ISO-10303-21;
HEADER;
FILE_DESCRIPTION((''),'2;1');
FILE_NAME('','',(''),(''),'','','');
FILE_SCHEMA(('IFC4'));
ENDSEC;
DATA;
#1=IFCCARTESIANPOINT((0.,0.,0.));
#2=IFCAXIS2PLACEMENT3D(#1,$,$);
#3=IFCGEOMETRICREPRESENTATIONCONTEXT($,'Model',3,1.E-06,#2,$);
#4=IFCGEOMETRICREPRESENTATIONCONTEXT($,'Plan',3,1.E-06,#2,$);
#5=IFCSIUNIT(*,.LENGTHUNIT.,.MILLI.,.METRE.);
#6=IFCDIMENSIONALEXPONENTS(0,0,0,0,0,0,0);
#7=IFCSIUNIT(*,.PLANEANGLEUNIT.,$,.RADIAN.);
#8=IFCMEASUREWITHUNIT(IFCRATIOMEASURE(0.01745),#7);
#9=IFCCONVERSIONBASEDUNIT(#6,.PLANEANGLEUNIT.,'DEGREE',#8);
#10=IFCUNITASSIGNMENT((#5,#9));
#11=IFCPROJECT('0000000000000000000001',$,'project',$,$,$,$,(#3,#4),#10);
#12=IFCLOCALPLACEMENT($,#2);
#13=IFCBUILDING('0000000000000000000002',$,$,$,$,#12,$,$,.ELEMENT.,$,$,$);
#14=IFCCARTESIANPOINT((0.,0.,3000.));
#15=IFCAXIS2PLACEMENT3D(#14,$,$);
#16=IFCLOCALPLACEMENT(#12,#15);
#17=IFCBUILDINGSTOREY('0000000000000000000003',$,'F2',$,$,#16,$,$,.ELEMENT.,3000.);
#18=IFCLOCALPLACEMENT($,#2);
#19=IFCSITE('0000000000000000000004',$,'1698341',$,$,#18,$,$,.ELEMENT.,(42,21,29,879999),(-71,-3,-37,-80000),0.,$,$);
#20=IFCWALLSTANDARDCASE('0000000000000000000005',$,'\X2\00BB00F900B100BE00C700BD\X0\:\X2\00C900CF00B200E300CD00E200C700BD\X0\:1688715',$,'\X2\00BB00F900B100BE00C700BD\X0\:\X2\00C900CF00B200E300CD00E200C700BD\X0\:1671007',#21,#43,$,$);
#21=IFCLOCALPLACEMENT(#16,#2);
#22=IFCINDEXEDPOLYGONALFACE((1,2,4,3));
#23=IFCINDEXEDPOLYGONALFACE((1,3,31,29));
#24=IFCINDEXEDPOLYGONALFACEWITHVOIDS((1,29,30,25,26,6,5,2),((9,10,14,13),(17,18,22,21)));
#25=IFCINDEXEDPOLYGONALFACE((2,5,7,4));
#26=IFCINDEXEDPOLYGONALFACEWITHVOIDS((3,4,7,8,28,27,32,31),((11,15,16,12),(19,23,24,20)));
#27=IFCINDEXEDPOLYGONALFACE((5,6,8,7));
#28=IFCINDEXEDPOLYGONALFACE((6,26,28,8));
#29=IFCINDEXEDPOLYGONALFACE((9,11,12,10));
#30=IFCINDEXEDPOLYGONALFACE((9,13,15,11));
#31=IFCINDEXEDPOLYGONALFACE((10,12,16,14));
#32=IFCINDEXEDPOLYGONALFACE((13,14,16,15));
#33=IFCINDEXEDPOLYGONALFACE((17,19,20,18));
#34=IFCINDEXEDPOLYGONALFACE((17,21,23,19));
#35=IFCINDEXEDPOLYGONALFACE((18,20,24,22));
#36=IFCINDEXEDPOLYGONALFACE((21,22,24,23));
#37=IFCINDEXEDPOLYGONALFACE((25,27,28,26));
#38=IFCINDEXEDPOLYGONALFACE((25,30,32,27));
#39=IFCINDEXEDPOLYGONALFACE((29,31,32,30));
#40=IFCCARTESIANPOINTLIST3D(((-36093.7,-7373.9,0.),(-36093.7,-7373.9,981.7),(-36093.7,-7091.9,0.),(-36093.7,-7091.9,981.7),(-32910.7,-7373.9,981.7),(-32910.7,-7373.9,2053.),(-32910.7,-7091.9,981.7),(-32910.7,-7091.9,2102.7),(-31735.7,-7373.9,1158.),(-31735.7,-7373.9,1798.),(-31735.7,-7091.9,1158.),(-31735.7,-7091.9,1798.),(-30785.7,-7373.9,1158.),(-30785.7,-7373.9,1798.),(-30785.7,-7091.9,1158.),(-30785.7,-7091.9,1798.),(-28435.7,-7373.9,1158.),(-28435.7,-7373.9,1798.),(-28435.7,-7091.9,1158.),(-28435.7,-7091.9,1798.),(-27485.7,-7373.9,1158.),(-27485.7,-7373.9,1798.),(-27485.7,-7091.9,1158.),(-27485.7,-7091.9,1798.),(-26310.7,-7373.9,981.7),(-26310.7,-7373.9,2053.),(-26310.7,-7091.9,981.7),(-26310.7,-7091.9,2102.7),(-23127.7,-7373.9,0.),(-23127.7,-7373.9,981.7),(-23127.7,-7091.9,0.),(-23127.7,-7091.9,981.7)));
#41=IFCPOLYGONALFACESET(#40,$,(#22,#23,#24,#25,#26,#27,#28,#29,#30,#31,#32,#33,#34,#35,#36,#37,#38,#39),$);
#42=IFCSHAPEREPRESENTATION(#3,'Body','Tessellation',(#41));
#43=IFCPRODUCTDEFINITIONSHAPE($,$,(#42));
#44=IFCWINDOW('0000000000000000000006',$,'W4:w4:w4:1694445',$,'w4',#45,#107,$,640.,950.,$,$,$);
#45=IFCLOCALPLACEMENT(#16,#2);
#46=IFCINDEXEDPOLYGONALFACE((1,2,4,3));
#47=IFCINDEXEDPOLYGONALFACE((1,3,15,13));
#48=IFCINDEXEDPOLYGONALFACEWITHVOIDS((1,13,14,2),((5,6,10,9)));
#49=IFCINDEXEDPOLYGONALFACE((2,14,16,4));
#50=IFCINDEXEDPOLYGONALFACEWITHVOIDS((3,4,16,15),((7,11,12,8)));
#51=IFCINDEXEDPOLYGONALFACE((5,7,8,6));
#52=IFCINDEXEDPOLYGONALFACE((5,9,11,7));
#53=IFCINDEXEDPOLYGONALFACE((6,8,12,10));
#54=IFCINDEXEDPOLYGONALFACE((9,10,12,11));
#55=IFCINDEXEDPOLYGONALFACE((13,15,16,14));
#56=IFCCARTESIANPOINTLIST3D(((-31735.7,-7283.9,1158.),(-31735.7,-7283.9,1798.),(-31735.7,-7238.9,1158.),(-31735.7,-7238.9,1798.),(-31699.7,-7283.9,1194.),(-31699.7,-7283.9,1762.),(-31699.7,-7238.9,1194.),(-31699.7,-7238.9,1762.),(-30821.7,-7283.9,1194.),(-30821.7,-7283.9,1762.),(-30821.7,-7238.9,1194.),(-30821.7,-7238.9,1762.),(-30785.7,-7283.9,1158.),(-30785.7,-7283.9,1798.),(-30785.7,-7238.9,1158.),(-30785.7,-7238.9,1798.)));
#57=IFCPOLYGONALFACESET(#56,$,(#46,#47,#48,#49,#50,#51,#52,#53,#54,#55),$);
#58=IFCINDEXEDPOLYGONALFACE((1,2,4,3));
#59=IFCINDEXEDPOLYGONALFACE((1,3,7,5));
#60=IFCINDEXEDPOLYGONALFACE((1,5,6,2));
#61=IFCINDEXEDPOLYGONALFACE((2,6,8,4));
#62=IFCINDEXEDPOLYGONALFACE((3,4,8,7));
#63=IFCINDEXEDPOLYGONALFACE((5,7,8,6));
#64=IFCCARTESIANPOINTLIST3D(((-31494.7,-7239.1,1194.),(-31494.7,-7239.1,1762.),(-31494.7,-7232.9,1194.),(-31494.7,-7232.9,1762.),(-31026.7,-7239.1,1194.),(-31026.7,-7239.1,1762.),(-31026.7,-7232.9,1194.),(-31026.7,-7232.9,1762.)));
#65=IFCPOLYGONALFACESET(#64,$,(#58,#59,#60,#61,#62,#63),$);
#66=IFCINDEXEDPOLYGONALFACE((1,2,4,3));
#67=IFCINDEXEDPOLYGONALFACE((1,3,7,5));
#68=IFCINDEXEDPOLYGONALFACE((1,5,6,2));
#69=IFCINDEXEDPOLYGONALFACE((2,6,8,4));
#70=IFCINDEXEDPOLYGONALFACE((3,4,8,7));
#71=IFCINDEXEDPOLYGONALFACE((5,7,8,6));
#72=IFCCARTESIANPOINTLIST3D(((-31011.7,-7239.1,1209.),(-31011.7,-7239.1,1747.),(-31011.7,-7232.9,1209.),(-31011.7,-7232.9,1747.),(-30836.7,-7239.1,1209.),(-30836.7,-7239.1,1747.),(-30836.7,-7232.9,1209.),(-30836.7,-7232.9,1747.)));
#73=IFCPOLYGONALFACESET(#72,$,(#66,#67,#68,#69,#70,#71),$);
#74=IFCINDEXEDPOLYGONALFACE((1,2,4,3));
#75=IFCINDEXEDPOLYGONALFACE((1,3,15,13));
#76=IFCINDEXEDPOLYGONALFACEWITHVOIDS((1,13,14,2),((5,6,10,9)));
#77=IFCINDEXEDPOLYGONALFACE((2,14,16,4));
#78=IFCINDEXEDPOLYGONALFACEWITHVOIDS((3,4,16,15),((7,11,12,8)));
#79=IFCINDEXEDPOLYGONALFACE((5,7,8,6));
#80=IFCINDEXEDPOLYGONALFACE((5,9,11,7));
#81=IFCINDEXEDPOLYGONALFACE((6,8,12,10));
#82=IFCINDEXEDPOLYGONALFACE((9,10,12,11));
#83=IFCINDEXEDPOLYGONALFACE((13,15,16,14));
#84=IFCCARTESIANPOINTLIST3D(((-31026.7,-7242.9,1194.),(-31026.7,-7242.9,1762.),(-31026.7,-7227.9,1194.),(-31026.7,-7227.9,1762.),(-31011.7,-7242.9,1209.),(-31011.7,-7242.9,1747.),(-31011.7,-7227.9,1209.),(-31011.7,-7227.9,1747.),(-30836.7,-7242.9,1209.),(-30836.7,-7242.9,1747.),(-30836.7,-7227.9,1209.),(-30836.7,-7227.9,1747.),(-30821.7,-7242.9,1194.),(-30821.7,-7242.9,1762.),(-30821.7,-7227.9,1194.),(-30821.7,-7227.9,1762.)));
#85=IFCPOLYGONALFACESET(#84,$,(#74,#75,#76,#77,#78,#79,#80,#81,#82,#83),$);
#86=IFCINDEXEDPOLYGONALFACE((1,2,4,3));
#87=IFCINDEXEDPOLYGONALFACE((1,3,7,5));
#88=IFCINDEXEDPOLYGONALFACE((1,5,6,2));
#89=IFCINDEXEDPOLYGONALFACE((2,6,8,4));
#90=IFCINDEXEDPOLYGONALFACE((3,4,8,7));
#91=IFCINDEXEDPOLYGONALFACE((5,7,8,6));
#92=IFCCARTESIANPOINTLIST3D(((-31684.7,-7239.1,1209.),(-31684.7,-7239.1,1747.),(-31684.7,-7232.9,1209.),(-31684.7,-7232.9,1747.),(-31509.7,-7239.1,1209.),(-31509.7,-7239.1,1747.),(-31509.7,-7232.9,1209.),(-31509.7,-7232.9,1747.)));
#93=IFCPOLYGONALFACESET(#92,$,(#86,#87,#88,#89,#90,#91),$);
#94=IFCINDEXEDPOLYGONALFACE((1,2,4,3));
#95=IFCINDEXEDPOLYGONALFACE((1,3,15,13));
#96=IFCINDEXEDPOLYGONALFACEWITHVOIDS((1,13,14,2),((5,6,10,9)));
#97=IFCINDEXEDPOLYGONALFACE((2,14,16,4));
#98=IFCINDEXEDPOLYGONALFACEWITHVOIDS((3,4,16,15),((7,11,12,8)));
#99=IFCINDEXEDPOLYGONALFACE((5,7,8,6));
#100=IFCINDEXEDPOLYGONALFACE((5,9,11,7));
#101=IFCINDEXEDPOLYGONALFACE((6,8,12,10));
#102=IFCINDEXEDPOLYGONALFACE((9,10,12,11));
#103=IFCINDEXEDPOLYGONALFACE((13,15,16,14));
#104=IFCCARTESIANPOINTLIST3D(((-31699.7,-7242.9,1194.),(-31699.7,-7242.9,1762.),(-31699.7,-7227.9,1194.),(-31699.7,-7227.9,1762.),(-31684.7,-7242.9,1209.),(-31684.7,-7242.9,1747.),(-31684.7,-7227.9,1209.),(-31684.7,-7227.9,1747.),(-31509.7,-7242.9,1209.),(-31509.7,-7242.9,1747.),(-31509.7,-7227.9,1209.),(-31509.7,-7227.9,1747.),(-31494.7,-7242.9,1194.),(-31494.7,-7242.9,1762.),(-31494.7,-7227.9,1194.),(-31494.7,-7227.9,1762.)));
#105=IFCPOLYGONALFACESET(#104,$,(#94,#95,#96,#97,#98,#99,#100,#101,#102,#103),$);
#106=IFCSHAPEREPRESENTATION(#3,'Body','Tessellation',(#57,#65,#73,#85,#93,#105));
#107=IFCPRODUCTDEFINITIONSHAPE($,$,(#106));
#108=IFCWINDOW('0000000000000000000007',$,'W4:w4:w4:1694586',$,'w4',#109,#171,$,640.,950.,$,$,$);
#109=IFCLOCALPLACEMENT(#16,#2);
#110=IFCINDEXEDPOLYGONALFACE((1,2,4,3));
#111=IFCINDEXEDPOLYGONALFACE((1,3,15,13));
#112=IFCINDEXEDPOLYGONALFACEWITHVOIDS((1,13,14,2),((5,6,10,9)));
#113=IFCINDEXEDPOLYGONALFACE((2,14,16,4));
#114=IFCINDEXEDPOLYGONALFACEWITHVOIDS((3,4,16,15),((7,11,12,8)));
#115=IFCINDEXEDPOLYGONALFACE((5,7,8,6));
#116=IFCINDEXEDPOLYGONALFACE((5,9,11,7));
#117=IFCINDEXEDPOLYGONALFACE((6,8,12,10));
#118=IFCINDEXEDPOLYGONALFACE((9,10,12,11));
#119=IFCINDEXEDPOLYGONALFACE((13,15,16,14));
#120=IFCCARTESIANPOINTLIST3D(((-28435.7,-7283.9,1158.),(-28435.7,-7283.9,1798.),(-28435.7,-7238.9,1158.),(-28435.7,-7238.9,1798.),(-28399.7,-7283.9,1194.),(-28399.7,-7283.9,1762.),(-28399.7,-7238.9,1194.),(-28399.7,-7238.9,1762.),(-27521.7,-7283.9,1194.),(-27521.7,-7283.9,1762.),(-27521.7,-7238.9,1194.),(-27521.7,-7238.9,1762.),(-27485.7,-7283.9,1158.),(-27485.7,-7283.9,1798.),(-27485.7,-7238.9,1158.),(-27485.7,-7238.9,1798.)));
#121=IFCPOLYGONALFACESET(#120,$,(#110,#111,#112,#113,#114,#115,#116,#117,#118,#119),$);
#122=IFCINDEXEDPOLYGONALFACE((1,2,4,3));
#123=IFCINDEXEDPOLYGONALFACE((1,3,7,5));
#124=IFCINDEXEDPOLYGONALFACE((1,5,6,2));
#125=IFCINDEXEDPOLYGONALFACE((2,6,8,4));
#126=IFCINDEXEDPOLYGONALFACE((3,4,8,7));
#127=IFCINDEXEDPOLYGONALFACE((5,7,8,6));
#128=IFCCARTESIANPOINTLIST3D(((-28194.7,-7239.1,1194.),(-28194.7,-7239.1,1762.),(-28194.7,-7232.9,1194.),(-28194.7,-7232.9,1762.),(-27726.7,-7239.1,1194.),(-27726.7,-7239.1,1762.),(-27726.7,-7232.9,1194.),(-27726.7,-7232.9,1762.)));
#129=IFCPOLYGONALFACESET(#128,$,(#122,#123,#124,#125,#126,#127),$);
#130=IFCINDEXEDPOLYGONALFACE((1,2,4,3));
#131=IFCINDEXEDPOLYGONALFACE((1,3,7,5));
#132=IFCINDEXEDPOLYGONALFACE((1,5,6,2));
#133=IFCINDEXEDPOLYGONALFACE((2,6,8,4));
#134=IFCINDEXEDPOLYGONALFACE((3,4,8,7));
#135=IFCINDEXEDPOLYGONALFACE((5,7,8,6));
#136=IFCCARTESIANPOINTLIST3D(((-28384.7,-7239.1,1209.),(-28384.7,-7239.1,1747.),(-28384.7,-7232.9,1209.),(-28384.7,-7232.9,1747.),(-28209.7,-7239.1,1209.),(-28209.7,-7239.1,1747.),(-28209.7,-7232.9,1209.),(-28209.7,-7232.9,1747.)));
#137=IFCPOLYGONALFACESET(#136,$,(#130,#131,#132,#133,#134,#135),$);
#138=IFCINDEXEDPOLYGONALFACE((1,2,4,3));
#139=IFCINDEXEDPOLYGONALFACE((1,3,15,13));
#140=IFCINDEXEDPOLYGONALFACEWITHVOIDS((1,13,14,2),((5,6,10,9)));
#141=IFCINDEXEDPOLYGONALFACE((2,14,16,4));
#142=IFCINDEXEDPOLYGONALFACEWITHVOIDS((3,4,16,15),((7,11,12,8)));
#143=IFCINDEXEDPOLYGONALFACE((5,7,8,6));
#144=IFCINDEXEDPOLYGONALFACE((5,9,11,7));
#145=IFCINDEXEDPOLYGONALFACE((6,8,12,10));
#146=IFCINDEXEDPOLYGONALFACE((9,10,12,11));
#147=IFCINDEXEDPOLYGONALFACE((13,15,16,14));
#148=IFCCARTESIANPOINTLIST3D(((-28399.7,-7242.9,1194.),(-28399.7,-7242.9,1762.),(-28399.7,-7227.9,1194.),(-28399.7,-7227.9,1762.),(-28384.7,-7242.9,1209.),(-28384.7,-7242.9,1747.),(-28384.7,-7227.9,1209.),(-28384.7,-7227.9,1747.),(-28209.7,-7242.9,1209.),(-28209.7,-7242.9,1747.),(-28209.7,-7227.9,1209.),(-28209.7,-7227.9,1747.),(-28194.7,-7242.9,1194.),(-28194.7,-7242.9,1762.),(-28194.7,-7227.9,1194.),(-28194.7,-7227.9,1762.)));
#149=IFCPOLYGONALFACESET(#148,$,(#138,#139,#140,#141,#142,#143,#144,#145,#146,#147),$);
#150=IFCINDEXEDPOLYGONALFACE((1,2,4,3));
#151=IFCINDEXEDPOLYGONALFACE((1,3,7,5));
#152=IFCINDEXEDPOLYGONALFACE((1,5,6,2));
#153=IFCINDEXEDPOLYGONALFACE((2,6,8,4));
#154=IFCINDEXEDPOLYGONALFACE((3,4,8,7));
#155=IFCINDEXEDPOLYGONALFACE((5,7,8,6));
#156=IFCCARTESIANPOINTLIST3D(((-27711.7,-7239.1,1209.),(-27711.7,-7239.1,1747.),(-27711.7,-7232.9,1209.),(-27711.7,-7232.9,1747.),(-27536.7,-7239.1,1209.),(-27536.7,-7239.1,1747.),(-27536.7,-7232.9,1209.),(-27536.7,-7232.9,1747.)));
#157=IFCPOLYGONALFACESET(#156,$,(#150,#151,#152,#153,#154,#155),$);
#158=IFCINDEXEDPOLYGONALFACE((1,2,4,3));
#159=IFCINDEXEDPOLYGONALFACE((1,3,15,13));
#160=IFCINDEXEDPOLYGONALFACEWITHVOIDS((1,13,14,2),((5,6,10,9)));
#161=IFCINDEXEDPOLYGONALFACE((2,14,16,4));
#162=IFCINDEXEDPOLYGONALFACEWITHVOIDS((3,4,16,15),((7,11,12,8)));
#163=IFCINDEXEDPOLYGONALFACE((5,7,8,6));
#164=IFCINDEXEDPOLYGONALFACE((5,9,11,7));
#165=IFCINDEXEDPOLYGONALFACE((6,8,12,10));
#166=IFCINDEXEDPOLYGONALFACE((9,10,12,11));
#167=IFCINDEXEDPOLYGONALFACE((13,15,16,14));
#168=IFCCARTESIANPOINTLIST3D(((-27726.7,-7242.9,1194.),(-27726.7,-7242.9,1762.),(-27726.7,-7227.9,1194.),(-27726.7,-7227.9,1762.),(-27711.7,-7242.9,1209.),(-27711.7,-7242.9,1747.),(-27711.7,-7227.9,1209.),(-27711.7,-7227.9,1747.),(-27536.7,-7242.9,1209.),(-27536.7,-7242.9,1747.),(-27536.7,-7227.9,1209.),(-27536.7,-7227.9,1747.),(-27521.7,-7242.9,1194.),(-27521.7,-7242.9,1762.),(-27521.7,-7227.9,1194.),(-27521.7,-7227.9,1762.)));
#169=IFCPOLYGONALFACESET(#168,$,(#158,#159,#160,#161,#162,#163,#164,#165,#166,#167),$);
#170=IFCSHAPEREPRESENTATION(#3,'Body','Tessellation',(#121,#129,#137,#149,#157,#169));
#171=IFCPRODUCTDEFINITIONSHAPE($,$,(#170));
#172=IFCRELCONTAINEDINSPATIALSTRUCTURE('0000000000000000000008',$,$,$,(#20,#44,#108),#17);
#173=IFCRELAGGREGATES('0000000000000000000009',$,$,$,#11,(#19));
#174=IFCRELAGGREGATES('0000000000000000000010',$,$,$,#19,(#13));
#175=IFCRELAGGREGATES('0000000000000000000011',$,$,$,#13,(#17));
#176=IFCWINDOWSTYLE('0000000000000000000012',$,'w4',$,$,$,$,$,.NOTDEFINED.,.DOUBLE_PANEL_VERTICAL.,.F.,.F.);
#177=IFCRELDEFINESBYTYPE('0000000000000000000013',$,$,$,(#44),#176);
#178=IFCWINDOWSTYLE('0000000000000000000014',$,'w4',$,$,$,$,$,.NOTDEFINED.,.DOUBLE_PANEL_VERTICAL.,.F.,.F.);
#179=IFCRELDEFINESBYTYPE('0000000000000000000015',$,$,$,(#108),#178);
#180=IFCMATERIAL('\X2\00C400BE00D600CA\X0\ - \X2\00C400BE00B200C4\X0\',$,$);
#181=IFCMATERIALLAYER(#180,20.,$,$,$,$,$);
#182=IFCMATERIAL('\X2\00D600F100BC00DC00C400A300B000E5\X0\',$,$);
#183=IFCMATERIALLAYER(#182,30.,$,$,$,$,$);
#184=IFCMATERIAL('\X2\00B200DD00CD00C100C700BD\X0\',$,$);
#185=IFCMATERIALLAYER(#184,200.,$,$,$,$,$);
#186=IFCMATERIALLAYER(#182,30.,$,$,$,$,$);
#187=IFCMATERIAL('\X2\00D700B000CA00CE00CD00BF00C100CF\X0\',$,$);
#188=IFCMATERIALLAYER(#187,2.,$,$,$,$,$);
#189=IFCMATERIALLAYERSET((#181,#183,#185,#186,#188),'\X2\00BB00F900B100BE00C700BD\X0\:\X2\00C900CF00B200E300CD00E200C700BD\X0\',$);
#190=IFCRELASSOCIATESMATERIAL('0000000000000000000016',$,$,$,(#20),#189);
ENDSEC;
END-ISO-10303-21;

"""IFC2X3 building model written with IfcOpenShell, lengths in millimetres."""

from ifc_helpers import new_model, entity, si_unit, converted_unit, frame, frame_2d, origin, origin_2d_with_axis, place, context, project, spatial, polyline, rectangle, outline, extrude, clip, halfspace, bounded_halfspace, source, transform, mapped, material, layer, layer_set, layer_usage, type_object, type_shapes, element, fill, save


model = new_model("IFC2X3")

# Units and contexts
model_context = context("Model", 3, precision=1e-06, world=origin())
plan_context = context("Plan", 3, precision=1e-06, world=origin())
ifc_project = project(units=[si_unit("LENGTHUNIT", "METRE", prefix="MILLI"), converted_unit("PLANEANGLEUNIT", "DEGREE", entity("IfcRatioMeasure", 0.01745), si_unit("PLANEANGLEUNIT", "RADIAN"), dimensions=[0, 0, 0, 0, 0, 0, 0])], contexts=[model_context, plan_context])

# Site, building, storey
site_placement = place(None, origin())
site = spatial("IfcSite", under=ifc_project, at=site_placement, Name="1698341", CompositionType="ELEMENT", RefLatitude=(42, 21, 29, 879999), RefLongitude=(-71, -3, -37, -80000), RefElevation=0.0)
building_placement = place(None, origin())
building = spatial("IfcBuilding", under=site, at=building_placement, CompositionType="ELEMENT")
storey_placement = place(building_placement, frame((0.0, 0.0, 3000.0)))
storey = spatial("IfcBuildingStorey", under=building, at=storey_placement, Name="F2", CompositionType="ELEMENT", Elevation=3000.0)

# Shared definitions
ifc_material_1 = material(Name="Öñ¼ÜÄ£°å")

# Shared definitions
ifc_material_2 = material(Name="Ä¾ÖÊ - Ä¾²Ä")
ifc_layer_1 = layer(ifc_material_2, 20.0)
ifc_layer_2 = layer(ifc_material_1, 30.0)
ifc_material_3 = material(Name="²ÝÍÁÇ½")
ifc_layer_3 = layer(ifc_material_3, 200.0)
ifc_layer_4 = layer(ifc_material_1, 30.0)
ifc_material_4 = material(Name="×°ÊÎÍ¿ÁÏ")
ifc_layer_5 = layer(ifc_material_4, 2.0)
ifc_layer_set_1 = layer_set([ifc_layer_1, ifc_layer_2, ifc_layer_3, ifc_layer_4, ifc_layer_5], Name="»ù±¾Ç½:ÉÏ²ãÍâÇ½")

# Shared definitions
window_style_1 = type_object("IfcWindowStyle", Name="w4", ConstructionType="NOTDEFINED", OperationType="DOUBLE_PANEL_VERTICAL", ParameterTakesPrecedence=False, Sizeable=False)
shared_shape_1 = source(origin(), model_context, "Body", "SweptSolid", [
    extrude(outline(polyline([(-320.0, -475.0), (320.0, -475.0), (320.0, 475.0), (-320.0, 475.0), (-320.0, -475.0)]), holes=[polyline([(284.0, -439.0), (-284.0, -439.0), (-284.0, 439.0), (284.0, 439.0), (284.0, -439.0)])]), frame((475.0, -135.0, 320.0), z_axis=(0.0, 1.0, 0.0), x_axis=(0.0, 0.0, 1.0)), (0.0, 0.0, 1.0), 45.0),
    extrude(rectangle(XDim=6.3, YDim=468.0, at=origin_2d_with_axis()), frame((475.0, -137.9, 36.0), z_axis=(0.0, 0.0, 1.0), x_axis=(0.0, 1.0, 0.0)), (0.0, 0.0, 1.0), 568.0),
    extrude(rectangle(XDim=6.3, YDim=175.0, at=origin_2d_with_axis()), frame((138.5, -137.9, 51.0), z_axis=(0.0, 0.0, 1.0), x_axis=(0.0, 1.0, 0.0)), (0.0, 0.0, 1.0), 538.0),
    extrude(outline(polyline([(-102.5, -284.0), (102.5, -284.0), (102.5, 284.0), (-102.5, 284.0), (-102.5, -284.0)]), holes=[polyline([(87.5, -269.0), (-87.5, -269.0), (-87.5, 269.0), (87.5, 269.0), (87.5, -269.0)])]), frame((138.5, -146.0, 320.0), z_axis=(0.0, 1.0, 0.0), x_axis=(-1.0, 0.0, 0.0)), (0.0, 0.0, 1.0), 15.0),
    extrude(rectangle(XDim=6.3, YDim=175.0, at=origin_2d_with_axis()), frame((811.5, -137.9, 51.0), z_axis=(0.0, 0.0, 1.0), x_axis=(0.0, 1.0, 0.0)), (0.0, 0.0, 1.0), 538.0),
    extrude(outline(polyline([(-102.5, -284.0), (102.5, -284.0), (102.5, 284.0), (-102.5, 284.0), (-102.5, -284.0)]), holes=[polyline([(87.5, -269.0), (-87.5, -269.0), (-87.5, 269.0), (87.5, 269.0), (87.5, -269.0)])]), frame((811.5, -146.0, 320.0), z_axis=(0.0, 1.0, 0.0), x_axis=(-1.0, 0.0, 0.0)), (0.0, 0.0, 1.0), 15.0),
])
type_shapes(window_style_1, [shared_shape_1])
window_style_2 = type_object("IfcWindowStyle", Name="w4", ConstructionType="NOTDEFINED", OperationType="DOUBLE_PANEL_VERTICAL", ParameterTakesPrecedence=False, Sizeable=False)
shared_shape_2 = source(origin(), model_context, "Body", "SweptSolid", [
    extrude(outline(polyline([(-475.0, -320.0), (475.0, -320.0), (475.0, 320.0), (-475.0, 320.0), (-475.0, -320.0)]), holes=[polyline([(-439.0, 284.0), (439.0, 284.0), (439.0, -284.0), (-439.0, -284.0), (-439.0, 284.0)])]), frame((-177.3, 192.0, 320.0), z_axis=(0.0, -1.0, 0.0), x_axis=(-1.0, 0.0, 0.0)), (0.0, 0.0, 1.0), 45.0),
    extrude(rectangle(XDim=468.0, YDim=6.3, at=origin_2d_with_axis()), frame((-177.3, 144.1, 36.0)), (0.0, 0.0, 1.0), 568.0),
    extrude(rectangle(XDim=175.0, YDim=6.3, at=origin_2d_with_axis()), frame((159.2, 144.1, 51.0)), (0.0, 0.0, 1.0), 538.0),
    extrude(outline(polyline([(-284.0, -102.5), (284.0, -102.5), (284.0, 102.5), (-284.0, 102.5), (-284.0, -102.5)]), holes=[polyline([(-269.0, 87.5), (269.0, 87.5), (269.0, -87.5), (-269.0, -87.5), (-269.0, 87.5)])]), frame((159.2, 151.0, 320.0), z_axis=(0.0, -1.0, 0.0), x_axis=(0.0, 0.0, 1.0)), (0.0, 0.0, 1.0), 15.0),
    extrude(rectangle(XDim=175.0, YDim=6.3, at=origin_2d_with_axis()), frame((-513.8, 144.1, 51.0)), (0.0, 0.0, 1.0), 538.0),
    extrude(outline(polyline([(-284.0, -102.5), (284.0, -102.5), (284.0, 102.5), (-284.0, 102.5), (-284.0, -102.5)]), holes=[polyline([(-269.0, 87.5), (269.0, 87.5), (269.0, -87.5), (-269.0, -87.5), (-269.0, 87.5)])]), frame((-513.8, 151.0, 320.0), z_axis=(0.0, -1.0, 0.0), x_axis=(0.0, 0.0, 1.0)), (0.0, 0.0, 1.0), 15.0),
])
type_shapes(window_style_2, [shared_shape_2])

# Wall, openings, windows
ifc_layer_usage_1 = layer_usage(ifc_layer_set_1, "AXIS2", "NEGATIVE", 141.0)
wall_1_placement = place(storey_placement, frame((-23127.7, -7232.9, 0.0), z_axis=(0.0, 0.0, 1.0), x_axis=(-1.0, 0.0, 0.0)))
wall_1 = element("IfcWallStandardCase", 1, at=wall_1_placement, inside=storey, material=ifc_layer_usage_1, Name="»ù±¾Ç½:ÉÏ²ãÍâÇ½:1688715", ObjectType="»ù±¾Ç½:ÉÏ²ãÍâÇ½:1671007", context=model_context, shape_type="Clipping", body=[
    clip(clip(clip(extrude(rectangle(XDim=12966.0, YDim=282.0, at=frame_2d((6483.0, 0.0), x_axis=(-1.0, 0.0))), origin(), (0.0, 0.0, 1.0), 3200.0), bounded_halfspace(frame((3098.0, -141.0, 2102.7), z_axis=(0.0, -0.1736, -0.9848), x_axis=(1.0, 0.0, 0.0)), True, frame((3098.0, -141.0, 2102.7)), polyline([(0.0, 0.0), (170.0, 0.0), (3280.0, 0.0), (3490.0, 0.0), (6600.0, 0.0), (6770.0, 0.0), (6770.0, 282.0), (0.0, 282.0), (0.0, 0.0)]))), halfspace(frame((13107.0, 0.0, 981.7), z_axis=(0.5551, 0.0, 0.8318), x_axis=(0.0, 1.0, 0.0)), False)), halfspace(frame((3183.0, 0.0, 3200.0), z_axis=(-0.5551, 0.0, 0.8318), x_axis=(0.0, 1.0, 0.0)), False)),
])
opening_1_placement = place(wall_1_placement, origin())
opening_1 = element("IfcOpeningElement", 2, at=opening_1_placement, cuts=wall_1, ObjectType="Opening", context=model_context, shape_type="SweptSolid", body=[
    extrude(rectangle(XDim=640.0, YDim=950.0, at=frame_2d((0.0, 0.0), x_axis=(0.0, 1.0))), frame((8133.0, -141.0, 1478.0), z_axis=(0.0, 1.0, 0.0), x_axis=(-1.0, 0.0, 0.0)), (0.0, 0.0, 1.0), 282.0),
])
opening_2_placement = place(wall_1_placement, origin())
opening_2 = element("IfcOpeningElement", 3, at=opening_2_placement, cuts=wall_1, ObjectType="Opening", context=model_context, shape_type="SweptSolid", body=[
    extrude(rectangle(XDim=640.0, YDim=950.0, at=origin_2d_with_axis()), frame((4833.0, -141.0, 1478.0), z_axis=(0.0, 1.0, 0.0), x_axis=(0.0, 0.0, 1.0)), (0.0, 0.0, 1.0), 282.0),
])
opening_3_placement = place(wall_1_placement, frame((10891.0, 141.0, 1721.1)))
element("IfcOpeningElement", 4, at=opening_3_placement, cuts=wall_1, ObjectType="Opening", context=model_context, shape_type="SweptSolid", body=[
    extrude(outline(polyline([(-2253.7, -615.1), (1742.5, -615.1), (511.2, 1230.1), (-2253.7, -615.1)])), frame((0.0, 0.0, 0.0), z_axis=(0.0, -1.0, 0.0), x_axis=(-0.8318, 0.0, 0.5551)), (0.0, 0.0, 1.0), 282.0),
])
opening_4_placement = place(wall_1_placement, frame((2075.0, 141.0, 1721.1)))
element("IfcOpeningElement", 5, at=opening_4_placement, cuts=wall_1, ObjectType="Opening", context=model_context, shape_type="SweptSolid", body=[
    extrude(outline(polyline([(-1742.5, -615.1), (2253.7, -615.1), (-511.2, 1230.1), (-1742.5, -615.1)])), frame((0.0, 0.0, 0.0), z_axis=(0.0, -1.0, 0.0), x_axis=(-0.8318, 0.0, -0.5551)), (0.0, 0.0, 1.0), 282.0),
])
window_1_placement = place(opening_1_placement, frame((7658.0, 141.0, 1158.0)))
window_1 = element("IfcWindow", 6, at=window_1_placement, inside=storey, type_object=window_style_1, Name="W4:w4:w4:1694445", ObjectType="w4", OverallHeight=640.0, OverallWidth=950.0, context=model_context, shape_type="MappedRepresentation", body=[
    mapped(shared_shape_1, transform((0.0, 0.0, 0.0), scale=1.0)),
])
fill(opening_1, window_1)
window_2_placement = place(opening_2_placement, frame((5010.3, -141.0, 1158.0)))
window_2 = element("IfcWindow", 7, at=window_2_placement, inside=storey, type_object=window_style_2, Name="W4:w4:w4:1694586", ObjectType="w4", OverallHeight=640.0, OverallWidth=950.0, context=model_context, shape_type="MappedRepresentation", body=[
    mapped(shared_shape_2, transform((0.0, 0.0, 0.0), scale=1.0)),
])
fill(opening_2, window_2)

save(model, "model.ifc")
